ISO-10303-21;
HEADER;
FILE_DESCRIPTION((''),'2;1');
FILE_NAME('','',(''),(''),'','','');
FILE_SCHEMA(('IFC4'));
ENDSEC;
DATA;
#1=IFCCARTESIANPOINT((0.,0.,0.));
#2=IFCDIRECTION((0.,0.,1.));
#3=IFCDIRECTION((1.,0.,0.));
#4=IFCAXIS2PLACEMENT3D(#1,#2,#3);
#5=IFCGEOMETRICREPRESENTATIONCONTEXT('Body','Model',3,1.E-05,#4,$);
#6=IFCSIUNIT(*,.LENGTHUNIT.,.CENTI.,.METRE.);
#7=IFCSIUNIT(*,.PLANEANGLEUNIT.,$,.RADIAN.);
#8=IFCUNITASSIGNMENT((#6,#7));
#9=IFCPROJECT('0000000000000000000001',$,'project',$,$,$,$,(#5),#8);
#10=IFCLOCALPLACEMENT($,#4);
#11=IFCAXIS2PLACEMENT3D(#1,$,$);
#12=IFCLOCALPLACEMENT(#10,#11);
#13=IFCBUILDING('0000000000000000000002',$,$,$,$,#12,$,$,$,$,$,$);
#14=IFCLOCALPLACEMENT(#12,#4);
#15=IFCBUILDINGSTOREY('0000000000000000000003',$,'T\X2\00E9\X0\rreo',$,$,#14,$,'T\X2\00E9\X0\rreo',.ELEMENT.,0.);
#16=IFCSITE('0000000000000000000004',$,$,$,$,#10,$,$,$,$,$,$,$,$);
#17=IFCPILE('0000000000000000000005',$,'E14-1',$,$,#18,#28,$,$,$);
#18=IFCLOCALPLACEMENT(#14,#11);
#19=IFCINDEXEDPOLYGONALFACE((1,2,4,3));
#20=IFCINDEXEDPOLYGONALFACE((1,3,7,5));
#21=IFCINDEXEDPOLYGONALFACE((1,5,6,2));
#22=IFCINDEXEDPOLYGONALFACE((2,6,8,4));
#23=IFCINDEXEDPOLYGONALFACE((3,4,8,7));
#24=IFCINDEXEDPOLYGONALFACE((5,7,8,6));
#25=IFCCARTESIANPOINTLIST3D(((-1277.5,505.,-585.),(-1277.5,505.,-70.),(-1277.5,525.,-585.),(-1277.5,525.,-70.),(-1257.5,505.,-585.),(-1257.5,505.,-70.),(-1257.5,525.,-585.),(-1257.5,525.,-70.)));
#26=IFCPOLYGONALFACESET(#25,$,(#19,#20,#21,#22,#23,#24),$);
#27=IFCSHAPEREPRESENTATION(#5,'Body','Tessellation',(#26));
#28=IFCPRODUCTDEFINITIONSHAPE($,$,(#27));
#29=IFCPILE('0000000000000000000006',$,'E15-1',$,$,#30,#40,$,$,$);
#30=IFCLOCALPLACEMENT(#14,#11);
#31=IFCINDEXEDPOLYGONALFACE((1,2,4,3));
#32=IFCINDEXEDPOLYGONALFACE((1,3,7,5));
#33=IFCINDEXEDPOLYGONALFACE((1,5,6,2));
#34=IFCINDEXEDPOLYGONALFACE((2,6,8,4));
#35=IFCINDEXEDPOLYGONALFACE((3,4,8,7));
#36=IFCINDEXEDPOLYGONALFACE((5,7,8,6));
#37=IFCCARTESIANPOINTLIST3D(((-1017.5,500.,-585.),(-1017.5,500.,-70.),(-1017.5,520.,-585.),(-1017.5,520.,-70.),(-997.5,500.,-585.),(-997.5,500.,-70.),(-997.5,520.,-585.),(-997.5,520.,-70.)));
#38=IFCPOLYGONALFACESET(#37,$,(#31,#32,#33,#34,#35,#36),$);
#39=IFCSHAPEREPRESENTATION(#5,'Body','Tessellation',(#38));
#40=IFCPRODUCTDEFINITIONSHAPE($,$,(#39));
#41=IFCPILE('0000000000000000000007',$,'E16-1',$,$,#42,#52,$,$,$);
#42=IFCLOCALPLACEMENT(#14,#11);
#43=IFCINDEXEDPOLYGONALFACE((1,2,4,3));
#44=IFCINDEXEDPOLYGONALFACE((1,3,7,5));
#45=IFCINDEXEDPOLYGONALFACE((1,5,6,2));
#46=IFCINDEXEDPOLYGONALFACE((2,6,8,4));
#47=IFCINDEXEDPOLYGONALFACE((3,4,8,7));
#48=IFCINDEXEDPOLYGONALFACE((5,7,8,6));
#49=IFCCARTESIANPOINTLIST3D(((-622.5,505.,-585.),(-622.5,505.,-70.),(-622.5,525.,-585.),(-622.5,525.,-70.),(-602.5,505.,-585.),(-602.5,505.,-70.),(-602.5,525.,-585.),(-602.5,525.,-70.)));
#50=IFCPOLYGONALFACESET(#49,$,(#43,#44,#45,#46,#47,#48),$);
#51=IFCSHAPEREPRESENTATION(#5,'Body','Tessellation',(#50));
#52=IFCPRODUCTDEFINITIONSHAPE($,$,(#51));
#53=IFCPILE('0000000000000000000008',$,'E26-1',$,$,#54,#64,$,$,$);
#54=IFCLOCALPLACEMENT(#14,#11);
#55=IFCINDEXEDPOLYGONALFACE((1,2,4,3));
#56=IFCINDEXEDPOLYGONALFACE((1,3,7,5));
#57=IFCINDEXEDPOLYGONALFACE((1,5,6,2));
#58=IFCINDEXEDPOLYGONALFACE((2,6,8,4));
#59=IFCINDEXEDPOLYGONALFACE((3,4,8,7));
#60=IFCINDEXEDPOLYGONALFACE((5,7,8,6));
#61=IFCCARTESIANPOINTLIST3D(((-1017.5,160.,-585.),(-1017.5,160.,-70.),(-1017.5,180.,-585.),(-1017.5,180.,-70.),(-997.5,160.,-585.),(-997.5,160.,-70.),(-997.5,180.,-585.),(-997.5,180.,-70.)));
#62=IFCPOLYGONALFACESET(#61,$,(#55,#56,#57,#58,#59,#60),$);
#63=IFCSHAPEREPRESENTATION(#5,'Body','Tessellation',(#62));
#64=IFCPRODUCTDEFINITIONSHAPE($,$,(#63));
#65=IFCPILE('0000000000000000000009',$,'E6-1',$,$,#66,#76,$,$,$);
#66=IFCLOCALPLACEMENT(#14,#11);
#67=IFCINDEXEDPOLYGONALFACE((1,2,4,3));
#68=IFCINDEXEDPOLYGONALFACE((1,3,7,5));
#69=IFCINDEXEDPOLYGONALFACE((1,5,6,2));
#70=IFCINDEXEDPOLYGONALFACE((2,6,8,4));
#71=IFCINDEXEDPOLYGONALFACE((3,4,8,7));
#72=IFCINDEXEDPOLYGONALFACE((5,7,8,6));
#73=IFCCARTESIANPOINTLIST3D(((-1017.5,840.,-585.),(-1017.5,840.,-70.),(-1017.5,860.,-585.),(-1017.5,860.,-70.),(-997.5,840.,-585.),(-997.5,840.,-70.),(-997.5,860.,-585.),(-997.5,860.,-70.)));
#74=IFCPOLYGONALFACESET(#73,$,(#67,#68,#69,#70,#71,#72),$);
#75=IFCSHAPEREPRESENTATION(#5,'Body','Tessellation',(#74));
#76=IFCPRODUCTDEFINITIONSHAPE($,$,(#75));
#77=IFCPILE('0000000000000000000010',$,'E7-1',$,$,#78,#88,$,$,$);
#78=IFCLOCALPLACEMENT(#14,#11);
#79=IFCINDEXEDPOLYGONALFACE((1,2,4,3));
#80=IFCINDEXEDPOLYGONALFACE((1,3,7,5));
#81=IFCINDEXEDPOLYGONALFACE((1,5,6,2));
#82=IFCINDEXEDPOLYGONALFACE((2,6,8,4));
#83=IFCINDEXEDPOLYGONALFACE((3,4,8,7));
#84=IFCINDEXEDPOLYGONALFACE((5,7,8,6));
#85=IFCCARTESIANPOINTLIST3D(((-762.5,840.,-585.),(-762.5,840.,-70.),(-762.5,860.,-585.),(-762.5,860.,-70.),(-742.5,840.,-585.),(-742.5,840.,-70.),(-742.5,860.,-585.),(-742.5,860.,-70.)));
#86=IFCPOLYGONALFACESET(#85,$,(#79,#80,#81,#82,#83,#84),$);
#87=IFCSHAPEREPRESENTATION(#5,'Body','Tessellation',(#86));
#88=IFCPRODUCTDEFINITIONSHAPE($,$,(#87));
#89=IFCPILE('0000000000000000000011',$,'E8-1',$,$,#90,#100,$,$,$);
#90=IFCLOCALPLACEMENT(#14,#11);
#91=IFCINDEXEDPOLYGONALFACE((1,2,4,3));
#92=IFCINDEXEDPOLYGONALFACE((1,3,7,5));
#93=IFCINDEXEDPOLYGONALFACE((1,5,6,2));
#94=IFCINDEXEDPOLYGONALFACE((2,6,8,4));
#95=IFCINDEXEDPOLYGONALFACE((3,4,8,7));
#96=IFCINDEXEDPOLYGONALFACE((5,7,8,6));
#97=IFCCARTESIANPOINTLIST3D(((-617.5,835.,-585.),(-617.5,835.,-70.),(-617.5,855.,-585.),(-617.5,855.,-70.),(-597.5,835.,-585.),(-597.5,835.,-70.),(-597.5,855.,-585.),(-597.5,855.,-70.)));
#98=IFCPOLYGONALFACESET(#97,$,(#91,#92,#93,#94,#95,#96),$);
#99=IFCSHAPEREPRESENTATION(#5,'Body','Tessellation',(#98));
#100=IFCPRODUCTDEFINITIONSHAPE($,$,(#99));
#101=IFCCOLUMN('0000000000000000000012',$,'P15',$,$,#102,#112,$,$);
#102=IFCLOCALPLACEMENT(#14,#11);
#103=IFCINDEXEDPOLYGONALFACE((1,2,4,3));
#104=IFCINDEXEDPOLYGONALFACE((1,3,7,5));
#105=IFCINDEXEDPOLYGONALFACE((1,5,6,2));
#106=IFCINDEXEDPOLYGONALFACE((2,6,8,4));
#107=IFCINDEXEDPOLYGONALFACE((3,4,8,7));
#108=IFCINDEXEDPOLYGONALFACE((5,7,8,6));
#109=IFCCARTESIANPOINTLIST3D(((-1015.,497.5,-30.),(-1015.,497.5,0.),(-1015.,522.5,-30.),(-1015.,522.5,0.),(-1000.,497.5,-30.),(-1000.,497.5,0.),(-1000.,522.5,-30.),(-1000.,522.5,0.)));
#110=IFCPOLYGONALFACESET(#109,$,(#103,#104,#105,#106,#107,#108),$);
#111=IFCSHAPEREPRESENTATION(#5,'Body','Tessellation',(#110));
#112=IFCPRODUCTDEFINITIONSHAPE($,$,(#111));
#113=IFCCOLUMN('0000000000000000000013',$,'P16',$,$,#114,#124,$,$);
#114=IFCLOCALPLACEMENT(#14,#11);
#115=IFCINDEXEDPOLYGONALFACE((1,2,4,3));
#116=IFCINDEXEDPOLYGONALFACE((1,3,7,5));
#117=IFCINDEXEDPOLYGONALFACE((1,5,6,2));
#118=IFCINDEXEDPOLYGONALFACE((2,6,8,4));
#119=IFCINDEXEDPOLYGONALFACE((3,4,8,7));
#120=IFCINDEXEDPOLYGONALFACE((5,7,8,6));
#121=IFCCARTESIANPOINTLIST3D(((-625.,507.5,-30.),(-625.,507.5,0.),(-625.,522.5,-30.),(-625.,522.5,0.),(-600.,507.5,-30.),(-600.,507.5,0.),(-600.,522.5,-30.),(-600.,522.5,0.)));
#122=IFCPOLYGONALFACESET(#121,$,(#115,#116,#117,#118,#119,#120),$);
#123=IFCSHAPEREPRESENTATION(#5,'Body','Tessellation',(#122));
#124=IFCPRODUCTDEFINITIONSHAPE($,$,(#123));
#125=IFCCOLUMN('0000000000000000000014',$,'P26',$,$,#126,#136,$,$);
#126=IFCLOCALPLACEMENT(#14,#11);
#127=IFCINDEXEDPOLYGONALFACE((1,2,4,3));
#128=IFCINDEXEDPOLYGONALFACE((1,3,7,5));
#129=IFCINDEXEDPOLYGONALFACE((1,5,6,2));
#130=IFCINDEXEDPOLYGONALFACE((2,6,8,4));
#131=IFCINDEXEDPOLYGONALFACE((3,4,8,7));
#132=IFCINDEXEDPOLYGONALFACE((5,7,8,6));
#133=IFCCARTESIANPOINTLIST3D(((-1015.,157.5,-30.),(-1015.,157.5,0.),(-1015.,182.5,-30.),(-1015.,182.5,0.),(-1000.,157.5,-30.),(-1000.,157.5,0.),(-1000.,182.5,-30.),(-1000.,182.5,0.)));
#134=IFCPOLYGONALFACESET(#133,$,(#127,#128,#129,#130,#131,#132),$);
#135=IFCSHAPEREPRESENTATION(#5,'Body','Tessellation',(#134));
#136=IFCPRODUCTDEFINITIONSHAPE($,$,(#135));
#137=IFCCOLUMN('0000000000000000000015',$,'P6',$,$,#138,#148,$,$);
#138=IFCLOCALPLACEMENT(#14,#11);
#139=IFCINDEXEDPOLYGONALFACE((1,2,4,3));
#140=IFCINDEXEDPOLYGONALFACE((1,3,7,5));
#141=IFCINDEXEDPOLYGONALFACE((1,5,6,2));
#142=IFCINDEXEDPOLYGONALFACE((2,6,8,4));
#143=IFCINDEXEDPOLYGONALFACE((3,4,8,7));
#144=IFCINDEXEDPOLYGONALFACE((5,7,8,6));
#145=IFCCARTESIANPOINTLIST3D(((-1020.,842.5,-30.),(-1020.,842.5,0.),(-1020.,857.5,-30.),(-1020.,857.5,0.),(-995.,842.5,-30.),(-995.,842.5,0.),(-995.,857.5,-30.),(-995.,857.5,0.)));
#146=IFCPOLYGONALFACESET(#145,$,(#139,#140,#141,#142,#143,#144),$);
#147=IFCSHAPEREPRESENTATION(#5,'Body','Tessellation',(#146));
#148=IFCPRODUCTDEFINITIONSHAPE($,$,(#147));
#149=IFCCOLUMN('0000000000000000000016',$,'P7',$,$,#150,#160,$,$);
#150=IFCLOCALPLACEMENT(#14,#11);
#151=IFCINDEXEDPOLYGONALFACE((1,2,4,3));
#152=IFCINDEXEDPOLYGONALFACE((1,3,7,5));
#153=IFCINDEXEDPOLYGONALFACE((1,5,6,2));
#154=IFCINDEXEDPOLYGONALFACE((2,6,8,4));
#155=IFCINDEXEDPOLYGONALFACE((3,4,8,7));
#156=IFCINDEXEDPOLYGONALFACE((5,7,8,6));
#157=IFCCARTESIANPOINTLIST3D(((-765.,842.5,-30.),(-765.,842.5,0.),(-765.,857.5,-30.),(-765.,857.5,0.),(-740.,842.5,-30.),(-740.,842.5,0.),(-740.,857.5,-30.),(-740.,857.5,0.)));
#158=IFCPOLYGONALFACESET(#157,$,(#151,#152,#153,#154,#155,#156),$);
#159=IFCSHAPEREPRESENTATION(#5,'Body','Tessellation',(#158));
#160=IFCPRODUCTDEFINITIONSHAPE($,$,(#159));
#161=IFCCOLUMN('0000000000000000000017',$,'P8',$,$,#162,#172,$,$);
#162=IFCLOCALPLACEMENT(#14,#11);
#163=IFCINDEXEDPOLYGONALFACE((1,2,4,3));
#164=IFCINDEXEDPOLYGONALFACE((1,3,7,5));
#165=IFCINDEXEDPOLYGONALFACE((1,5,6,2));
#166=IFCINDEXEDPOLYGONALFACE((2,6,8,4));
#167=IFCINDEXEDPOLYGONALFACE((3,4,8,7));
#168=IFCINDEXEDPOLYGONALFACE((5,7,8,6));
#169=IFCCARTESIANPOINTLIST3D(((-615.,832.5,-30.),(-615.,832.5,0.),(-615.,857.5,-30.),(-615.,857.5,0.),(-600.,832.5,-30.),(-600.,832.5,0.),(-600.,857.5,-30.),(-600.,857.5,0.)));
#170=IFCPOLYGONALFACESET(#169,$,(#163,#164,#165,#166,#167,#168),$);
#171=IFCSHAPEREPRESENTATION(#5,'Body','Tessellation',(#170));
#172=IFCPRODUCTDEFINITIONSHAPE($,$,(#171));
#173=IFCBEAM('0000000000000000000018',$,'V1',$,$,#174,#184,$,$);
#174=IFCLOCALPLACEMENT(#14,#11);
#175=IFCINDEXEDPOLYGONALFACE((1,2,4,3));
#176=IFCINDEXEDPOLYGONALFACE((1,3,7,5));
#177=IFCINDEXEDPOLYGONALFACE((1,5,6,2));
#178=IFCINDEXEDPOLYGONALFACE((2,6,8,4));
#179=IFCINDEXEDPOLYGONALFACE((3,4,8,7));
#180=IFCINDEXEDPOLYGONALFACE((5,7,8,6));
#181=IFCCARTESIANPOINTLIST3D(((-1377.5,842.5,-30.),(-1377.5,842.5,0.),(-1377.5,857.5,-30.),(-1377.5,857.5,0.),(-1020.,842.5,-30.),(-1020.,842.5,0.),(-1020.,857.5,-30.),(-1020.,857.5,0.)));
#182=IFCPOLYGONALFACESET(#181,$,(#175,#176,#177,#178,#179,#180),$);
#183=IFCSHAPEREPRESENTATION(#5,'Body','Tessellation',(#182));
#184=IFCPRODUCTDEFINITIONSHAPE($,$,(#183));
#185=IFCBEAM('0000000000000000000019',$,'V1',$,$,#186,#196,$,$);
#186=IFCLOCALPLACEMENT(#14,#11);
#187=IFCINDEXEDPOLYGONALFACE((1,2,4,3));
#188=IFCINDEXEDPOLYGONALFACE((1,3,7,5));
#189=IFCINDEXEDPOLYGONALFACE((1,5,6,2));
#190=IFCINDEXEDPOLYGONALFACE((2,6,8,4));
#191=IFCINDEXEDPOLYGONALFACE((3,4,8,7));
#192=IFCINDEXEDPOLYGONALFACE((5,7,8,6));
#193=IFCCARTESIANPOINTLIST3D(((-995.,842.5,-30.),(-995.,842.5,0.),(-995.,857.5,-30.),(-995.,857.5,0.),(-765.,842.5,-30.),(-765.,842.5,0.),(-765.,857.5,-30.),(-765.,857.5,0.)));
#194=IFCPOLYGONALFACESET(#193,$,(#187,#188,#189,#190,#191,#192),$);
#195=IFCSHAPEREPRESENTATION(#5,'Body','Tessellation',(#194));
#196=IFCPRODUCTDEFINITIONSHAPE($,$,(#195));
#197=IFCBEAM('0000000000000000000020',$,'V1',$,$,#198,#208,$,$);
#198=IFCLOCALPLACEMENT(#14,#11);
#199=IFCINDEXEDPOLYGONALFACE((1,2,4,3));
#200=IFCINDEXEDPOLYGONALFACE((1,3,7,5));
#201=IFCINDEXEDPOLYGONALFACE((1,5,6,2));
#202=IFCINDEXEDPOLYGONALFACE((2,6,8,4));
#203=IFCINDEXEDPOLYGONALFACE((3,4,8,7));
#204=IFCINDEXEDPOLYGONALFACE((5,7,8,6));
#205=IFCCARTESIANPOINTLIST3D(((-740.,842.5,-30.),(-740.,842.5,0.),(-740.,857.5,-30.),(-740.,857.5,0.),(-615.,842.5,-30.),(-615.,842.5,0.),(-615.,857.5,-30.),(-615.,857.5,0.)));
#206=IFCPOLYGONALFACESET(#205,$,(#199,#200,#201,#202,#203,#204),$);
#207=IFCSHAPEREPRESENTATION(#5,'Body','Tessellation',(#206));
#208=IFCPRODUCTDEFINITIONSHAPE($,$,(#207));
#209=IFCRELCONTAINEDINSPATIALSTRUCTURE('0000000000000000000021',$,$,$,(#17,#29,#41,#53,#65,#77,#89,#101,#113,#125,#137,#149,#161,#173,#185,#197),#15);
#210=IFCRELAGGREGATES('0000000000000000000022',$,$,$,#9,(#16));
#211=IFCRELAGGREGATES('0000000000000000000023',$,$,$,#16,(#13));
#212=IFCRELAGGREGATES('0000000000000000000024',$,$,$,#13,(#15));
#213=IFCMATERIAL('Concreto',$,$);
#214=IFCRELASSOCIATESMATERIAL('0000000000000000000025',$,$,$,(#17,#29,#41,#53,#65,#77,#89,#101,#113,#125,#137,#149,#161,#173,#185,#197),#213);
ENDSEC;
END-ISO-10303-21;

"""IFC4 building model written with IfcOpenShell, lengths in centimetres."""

from ifc_helpers import new_model, si_unit, frame, origin, origin_with_axes, origin_2d_with_axis, place, context, project, spatial, rectangle, extrude, material, element, save


model = new_model("IFC4")

# Units and contexts
model_context = context("Model", 3, precision=1e-05, world=origin_with_axes(), identifier="Body")
ifc_project = project(units=[si_unit("LENGTHUNIT", "METRE", prefix="CENTI"), si_unit("PLANEANGLEUNIT", "RADIAN")], contexts=[model_context])

# Site, building, storey
site_placement = place(None, origin_with_axes())
site = spatial("IfcSite", under=ifc_project, at=site_placement)
building_placement = place(site_placement, origin())
building = spatial("IfcBuilding", under=site, at=building_placement)
storey_placement = place(building_placement, origin_with_axes())
storey = spatial("IfcBuildingStorey", under=building, at=storey_placement, Name="Térreo", LongName="Térreo", CompositionType="ELEMENT", Elevation=0.0)

# Piles
ifc_material = material(Name="Concreto")
pile_1_placement = place(storey_placement, frame((-1267.5, 515.0, -70.0), z_axis=(0.0, 0.0, 1.0), x_axis=(1.0, 0.0, 0.0)))
element("IfcPile", 1, at=pile_1_placement, inside=storey, material=ifc_material, Name="E14-1", context=model_context, shape_type="SweptSolid", body=[
    extrude(rectangle(XDim=20.0, YDim=20.0, at=origin_2d_with_axis()), frame((0.0, 0.0, -515.0), z_axis=(0.0, 0.0, 1.0), x_axis=(0.0, 1.0, 0.0)), (0.0, 0.0, 1.0), 515.0),
])
pile_2_placement = place(storey_placement, frame((-1007.5, 510.0, -70.0), z_axis=(0.0, 0.0, 1.0), x_axis=(1.0, 0.0, 0.0)))
element("IfcPile", 2, at=pile_2_placement, inside=storey, material=ifc_material, Name="E15-1", context=model_context, shape_type="SweptSolid", body=[
    extrude(rectangle(XDim=20.0, YDim=20.0, at=origin_2d_with_axis()), frame((0.0, 0.0, -515.0), z_axis=(0.0, 0.0, 1.0), x_axis=(1.0, 0.0, 0.0)), (0.0, 0.0, 1.0), 515.0),
])
pile_3_placement = place(storey_placement, frame((-612.5, 515.0, -70.0), z_axis=(0.0, 0.0, 1.0), x_axis=(1.0, 0.0, 0.0)))
element("IfcPile", 3, at=pile_3_placement, inside=storey, material=ifc_material, Name="E16-1", context=model_context, shape_type="SweptSolid", body=[
    extrude(rectangle(XDim=20.0, YDim=20.0, at=origin_2d_with_axis()), frame((0.0, 0.0, -515.0), z_axis=(0.0, 0.0, 1.0), x_axis=(0.0, -1.0, 0.0)), (0.0, 0.0, 1.0), 515.0),
])
pile_4_placement = place(storey_placement, frame((-1007.5, 170.0, -70.0), z_axis=(0.0, 0.0, 1.0), x_axis=(1.0, 0.0, 0.0)))
element("IfcPile", 4, at=pile_4_placement, inside=storey, material=ifc_material, Name="E26-1", context=model_context, shape_type="SweptSolid", body=[
    extrude(rectangle(XDim=20.0, YDim=20.0, at=origin_2d_with_axis()), frame((0.0, 0.0, -515.0), z_axis=(0.0, 0.0, 1.0), x_axis=(1.0, 0.0, 0.0)), (0.0, 0.0, 1.0), 515.0),
])
for number, where, z_axis, x_axis, name in (
    (5, (-1007.5, 850.0, -70.0), (0.0, 0.0, 1.0), (1.0, 0.0, 0.0), "E6-1"),
    (6, (-752.5, 850.0, -70.0), (0.0, 0.0, 1.0), (1.0, 0.0, 0.0), "E7-1"),
):
    element("IfcPile", number, at=place(storey_placement, frame(where, z_axis=z_axis, x_axis=x_axis)), inside=storey, material=ifc_material, Name=name, context=model_context, shape_type="SweptSolid", body=[
        extrude(rectangle(XDim=20.0, YDim=20.0, at=origin_2d_with_axis()), frame((0.0, 0.0, -515.0), z_axis=(0.0, 0.0, 1.0), x_axis=(0.0, 1.0, 0.0)), (0.0, 0.0, 1.0), 515.0),
    ])
pile_5_placement = place(storey_placement, frame((-607.5, 845.0, -70.0), z_axis=(0.0, 0.0, 1.0), x_axis=(1.0, 0.0, 0.0)))
element("IfcPile", 7, at=pile_5_placement, inside=storey, material=ifc_material, Name="E8-1", context=model_context, shape_type="SweptSolid", body=[
    extrude(rectangle(XDim=20.0, YDim=20.0, at=origin_2d_with_axis()), frame((0.0, 0.0, -515.0), z_axis=(0.0, 0.0, 1.0), x_axis=(-1.0, 0.0, 0.0)), (0.0, 0.0, 1.0), 515.0),
])

# Columns
column_1_placement = place(storey_placement, frame((-1007.5, 510.0, 0.0), z_axis=(0.0, 0.0, 1.0), x_axis=(1.0, 0.0, 0.0)))
element("IfcColumn", 8, at=column_1_placement, inside=storey, material=ifc_material, Name="P15", context=model_context, shape_type="SolidModel", body=[
    extrude(rectangle(XDim=15.0, YDim=25.0, at=origin_2d_with_axis()), frame((0.0, 0.0, -30.0), z_axis=(0.0, 0.0, 1.0), x_axis=(1.0, 0.0, 0.0)), (0.0, 0.0, 1.0), 30.0),
])
column_2_placement = place(storey_placement, frame((-612.5, 515.0, 0.0), z_axis=(0.0, 0.0, 1.0), x_axis=(1.0, 0.0, 0.0)))
element("IfcColumn", 9, at=column_2_placement, inside=storey, material=ifc_material, Name="P16", context=model_context, shape_type="SolidModel", body=[
    extrude(rectangle(XDim=15.0, YDim=25.0, at=origin_2d_with_axis()), frame((0.0, 0.0, -30.0), z_axis=(0.0, 0.0, 1.0), x_axis=(0.0, -1.0, 0.0)), (0.0, 0.0, 1.0), 30.0),
])
column_3_placement = place(storey_placement, frame((-1007.5, 170.0, 0.0), z_axis=(0.0, 0.0, 1.0), x_axis=(1.0, 0.0, 0.0)))
element("IfcColumn", 10, at=column_3_placement, inside=storey, material=ifc_material, Name="P26", context=model_context, shape_type="SolidModel", body=[
    extrude(rectangle(XDim=15.0, YDim=25.0, at=origin_2d_with_axis()), frame((0.0, 0.0, -30.0), z_axis=(0.0, 0.0, 1.0), x_axis=(1.0, 0.0, 0.0)), (0.0, 0.0, 1.0), 30.0),
])
for number, where, z_axis, x_axis, name in (
    (11, (-1007.5, 850.0, 0.0), (0.0, 0.0, 1.0), (1.0, 0.0, 0.0), "P6"),
    (12, (-752.5, 850.0, 0.0), (0.0, 0.0, 1.0), (1.0, 0.0, 0.0), "P7"),
):
    element("IfcColumn", number, at=place(storey_placement, frame(where, z_axis=z_axis, x_axis=x_axis)), inside=storey, material=ifc_material, Name=name, context=model_context, shape_type="SolidModel", body=[
        extrude(rectangle(XDim=15.0, YDim=25.0, at=origin_2d_with_axis()), frame((0.0, 0.0, -30.0), z_axis=(0.0, 0.0, 1.0), x_axis=(0.0, 1.0, 0.0)), (0.0, 0.0, 1.0), 30.0),
    ])
column_4_placement = place(storey_placement, frame((-607.5, 845.0, 0.0), z_axis=(0.0, 0.0, 1.0), x_axis=(1.0, 0.0, 0.0)))
element("IfcColumn", 13, at=column_4_placement, inside=storey, material=ifc_material, Name="P8", context=model_context, shape_type="SolidModel", body=[
    extrude(rectangle(XDim=15.0, YDim=25.0, at=origin_2d_with_axis()), frame((0.0, 0.0, -30.0), z_axis=(0.0, 0.0, 1.0), x_axis=(-1.0, 0.0, 0.0)), (0.0, 0.0, 1.0), 30.0),
])

# Beams
beam_1_placement = place(storey_placement, frame((-1198.75, 850.0, 0.0), z_axis=(0.0, 0.0, 1.0), x_axis=(1.0, 0.0, 0.0)))
element("IfcBeam", 14, at=beam_1_placement, inside=storey, material=ifc_material, Name="V1", context=model_context, shape_type="SolidModel", body=[
    extrude(rectangle(XDim=15.0, YDim=30.0, at=origin_2d_with_axis()), frame((-178.75, 0.0, -15.0), z_axis=(1.0, 0.0, 0.0), x_axis=(0.0, -1.0, 0.0)), (0.0, 0.0, 1.0), 357.5),
])
beam_2_placement = place(storey_placement, frame((-880.0, 850.0, 0.0), z_axis=(0.0, 0.0, 1.0), x_axis=(1.0, 0.0, 0.0)))
element("IfcBeam", 15, at=beam_2_placement, inside=storey, material=ifc_material, Name="V1", context=model_context, shape_type="SolidModel", body=[
    extrude(rectangle(XDim=15.0, YDim=30.0, at=origin_2d_with_axis()), frame((-115.0, 0.0, -15.0), z_axis=(1.0, 0.0, 0.0), x_axis=(0.0, 1.0, 0.0)), (0.0, 0.0, 1.0), 230.0),
])
beam_3_placement = place(storey_placement, frame((-677.5, 850.0, 0.0), z_axis=(0.0, 0.0, 1.0), x_axis=(1.0, 0.0, 0.0)))
element("IfcBeam", 16, at=beam_3_placement, inside=storey, material=ifc_material, Name="V1", context=model_context, shape_type="SolidModel", body=[
    extrude(rectangle(XDim=15.0, YDim=30.0, at=origin_2d_with_axis()), frame((-62.5, 0.0, -15.0), z_axis=(1.0, 0.0, 0.0), x_axis=(0.0, 1.0, 0.0)), (0.0, 0.0, 1.0), 125.0),
])

save(model, "model.ifc")
